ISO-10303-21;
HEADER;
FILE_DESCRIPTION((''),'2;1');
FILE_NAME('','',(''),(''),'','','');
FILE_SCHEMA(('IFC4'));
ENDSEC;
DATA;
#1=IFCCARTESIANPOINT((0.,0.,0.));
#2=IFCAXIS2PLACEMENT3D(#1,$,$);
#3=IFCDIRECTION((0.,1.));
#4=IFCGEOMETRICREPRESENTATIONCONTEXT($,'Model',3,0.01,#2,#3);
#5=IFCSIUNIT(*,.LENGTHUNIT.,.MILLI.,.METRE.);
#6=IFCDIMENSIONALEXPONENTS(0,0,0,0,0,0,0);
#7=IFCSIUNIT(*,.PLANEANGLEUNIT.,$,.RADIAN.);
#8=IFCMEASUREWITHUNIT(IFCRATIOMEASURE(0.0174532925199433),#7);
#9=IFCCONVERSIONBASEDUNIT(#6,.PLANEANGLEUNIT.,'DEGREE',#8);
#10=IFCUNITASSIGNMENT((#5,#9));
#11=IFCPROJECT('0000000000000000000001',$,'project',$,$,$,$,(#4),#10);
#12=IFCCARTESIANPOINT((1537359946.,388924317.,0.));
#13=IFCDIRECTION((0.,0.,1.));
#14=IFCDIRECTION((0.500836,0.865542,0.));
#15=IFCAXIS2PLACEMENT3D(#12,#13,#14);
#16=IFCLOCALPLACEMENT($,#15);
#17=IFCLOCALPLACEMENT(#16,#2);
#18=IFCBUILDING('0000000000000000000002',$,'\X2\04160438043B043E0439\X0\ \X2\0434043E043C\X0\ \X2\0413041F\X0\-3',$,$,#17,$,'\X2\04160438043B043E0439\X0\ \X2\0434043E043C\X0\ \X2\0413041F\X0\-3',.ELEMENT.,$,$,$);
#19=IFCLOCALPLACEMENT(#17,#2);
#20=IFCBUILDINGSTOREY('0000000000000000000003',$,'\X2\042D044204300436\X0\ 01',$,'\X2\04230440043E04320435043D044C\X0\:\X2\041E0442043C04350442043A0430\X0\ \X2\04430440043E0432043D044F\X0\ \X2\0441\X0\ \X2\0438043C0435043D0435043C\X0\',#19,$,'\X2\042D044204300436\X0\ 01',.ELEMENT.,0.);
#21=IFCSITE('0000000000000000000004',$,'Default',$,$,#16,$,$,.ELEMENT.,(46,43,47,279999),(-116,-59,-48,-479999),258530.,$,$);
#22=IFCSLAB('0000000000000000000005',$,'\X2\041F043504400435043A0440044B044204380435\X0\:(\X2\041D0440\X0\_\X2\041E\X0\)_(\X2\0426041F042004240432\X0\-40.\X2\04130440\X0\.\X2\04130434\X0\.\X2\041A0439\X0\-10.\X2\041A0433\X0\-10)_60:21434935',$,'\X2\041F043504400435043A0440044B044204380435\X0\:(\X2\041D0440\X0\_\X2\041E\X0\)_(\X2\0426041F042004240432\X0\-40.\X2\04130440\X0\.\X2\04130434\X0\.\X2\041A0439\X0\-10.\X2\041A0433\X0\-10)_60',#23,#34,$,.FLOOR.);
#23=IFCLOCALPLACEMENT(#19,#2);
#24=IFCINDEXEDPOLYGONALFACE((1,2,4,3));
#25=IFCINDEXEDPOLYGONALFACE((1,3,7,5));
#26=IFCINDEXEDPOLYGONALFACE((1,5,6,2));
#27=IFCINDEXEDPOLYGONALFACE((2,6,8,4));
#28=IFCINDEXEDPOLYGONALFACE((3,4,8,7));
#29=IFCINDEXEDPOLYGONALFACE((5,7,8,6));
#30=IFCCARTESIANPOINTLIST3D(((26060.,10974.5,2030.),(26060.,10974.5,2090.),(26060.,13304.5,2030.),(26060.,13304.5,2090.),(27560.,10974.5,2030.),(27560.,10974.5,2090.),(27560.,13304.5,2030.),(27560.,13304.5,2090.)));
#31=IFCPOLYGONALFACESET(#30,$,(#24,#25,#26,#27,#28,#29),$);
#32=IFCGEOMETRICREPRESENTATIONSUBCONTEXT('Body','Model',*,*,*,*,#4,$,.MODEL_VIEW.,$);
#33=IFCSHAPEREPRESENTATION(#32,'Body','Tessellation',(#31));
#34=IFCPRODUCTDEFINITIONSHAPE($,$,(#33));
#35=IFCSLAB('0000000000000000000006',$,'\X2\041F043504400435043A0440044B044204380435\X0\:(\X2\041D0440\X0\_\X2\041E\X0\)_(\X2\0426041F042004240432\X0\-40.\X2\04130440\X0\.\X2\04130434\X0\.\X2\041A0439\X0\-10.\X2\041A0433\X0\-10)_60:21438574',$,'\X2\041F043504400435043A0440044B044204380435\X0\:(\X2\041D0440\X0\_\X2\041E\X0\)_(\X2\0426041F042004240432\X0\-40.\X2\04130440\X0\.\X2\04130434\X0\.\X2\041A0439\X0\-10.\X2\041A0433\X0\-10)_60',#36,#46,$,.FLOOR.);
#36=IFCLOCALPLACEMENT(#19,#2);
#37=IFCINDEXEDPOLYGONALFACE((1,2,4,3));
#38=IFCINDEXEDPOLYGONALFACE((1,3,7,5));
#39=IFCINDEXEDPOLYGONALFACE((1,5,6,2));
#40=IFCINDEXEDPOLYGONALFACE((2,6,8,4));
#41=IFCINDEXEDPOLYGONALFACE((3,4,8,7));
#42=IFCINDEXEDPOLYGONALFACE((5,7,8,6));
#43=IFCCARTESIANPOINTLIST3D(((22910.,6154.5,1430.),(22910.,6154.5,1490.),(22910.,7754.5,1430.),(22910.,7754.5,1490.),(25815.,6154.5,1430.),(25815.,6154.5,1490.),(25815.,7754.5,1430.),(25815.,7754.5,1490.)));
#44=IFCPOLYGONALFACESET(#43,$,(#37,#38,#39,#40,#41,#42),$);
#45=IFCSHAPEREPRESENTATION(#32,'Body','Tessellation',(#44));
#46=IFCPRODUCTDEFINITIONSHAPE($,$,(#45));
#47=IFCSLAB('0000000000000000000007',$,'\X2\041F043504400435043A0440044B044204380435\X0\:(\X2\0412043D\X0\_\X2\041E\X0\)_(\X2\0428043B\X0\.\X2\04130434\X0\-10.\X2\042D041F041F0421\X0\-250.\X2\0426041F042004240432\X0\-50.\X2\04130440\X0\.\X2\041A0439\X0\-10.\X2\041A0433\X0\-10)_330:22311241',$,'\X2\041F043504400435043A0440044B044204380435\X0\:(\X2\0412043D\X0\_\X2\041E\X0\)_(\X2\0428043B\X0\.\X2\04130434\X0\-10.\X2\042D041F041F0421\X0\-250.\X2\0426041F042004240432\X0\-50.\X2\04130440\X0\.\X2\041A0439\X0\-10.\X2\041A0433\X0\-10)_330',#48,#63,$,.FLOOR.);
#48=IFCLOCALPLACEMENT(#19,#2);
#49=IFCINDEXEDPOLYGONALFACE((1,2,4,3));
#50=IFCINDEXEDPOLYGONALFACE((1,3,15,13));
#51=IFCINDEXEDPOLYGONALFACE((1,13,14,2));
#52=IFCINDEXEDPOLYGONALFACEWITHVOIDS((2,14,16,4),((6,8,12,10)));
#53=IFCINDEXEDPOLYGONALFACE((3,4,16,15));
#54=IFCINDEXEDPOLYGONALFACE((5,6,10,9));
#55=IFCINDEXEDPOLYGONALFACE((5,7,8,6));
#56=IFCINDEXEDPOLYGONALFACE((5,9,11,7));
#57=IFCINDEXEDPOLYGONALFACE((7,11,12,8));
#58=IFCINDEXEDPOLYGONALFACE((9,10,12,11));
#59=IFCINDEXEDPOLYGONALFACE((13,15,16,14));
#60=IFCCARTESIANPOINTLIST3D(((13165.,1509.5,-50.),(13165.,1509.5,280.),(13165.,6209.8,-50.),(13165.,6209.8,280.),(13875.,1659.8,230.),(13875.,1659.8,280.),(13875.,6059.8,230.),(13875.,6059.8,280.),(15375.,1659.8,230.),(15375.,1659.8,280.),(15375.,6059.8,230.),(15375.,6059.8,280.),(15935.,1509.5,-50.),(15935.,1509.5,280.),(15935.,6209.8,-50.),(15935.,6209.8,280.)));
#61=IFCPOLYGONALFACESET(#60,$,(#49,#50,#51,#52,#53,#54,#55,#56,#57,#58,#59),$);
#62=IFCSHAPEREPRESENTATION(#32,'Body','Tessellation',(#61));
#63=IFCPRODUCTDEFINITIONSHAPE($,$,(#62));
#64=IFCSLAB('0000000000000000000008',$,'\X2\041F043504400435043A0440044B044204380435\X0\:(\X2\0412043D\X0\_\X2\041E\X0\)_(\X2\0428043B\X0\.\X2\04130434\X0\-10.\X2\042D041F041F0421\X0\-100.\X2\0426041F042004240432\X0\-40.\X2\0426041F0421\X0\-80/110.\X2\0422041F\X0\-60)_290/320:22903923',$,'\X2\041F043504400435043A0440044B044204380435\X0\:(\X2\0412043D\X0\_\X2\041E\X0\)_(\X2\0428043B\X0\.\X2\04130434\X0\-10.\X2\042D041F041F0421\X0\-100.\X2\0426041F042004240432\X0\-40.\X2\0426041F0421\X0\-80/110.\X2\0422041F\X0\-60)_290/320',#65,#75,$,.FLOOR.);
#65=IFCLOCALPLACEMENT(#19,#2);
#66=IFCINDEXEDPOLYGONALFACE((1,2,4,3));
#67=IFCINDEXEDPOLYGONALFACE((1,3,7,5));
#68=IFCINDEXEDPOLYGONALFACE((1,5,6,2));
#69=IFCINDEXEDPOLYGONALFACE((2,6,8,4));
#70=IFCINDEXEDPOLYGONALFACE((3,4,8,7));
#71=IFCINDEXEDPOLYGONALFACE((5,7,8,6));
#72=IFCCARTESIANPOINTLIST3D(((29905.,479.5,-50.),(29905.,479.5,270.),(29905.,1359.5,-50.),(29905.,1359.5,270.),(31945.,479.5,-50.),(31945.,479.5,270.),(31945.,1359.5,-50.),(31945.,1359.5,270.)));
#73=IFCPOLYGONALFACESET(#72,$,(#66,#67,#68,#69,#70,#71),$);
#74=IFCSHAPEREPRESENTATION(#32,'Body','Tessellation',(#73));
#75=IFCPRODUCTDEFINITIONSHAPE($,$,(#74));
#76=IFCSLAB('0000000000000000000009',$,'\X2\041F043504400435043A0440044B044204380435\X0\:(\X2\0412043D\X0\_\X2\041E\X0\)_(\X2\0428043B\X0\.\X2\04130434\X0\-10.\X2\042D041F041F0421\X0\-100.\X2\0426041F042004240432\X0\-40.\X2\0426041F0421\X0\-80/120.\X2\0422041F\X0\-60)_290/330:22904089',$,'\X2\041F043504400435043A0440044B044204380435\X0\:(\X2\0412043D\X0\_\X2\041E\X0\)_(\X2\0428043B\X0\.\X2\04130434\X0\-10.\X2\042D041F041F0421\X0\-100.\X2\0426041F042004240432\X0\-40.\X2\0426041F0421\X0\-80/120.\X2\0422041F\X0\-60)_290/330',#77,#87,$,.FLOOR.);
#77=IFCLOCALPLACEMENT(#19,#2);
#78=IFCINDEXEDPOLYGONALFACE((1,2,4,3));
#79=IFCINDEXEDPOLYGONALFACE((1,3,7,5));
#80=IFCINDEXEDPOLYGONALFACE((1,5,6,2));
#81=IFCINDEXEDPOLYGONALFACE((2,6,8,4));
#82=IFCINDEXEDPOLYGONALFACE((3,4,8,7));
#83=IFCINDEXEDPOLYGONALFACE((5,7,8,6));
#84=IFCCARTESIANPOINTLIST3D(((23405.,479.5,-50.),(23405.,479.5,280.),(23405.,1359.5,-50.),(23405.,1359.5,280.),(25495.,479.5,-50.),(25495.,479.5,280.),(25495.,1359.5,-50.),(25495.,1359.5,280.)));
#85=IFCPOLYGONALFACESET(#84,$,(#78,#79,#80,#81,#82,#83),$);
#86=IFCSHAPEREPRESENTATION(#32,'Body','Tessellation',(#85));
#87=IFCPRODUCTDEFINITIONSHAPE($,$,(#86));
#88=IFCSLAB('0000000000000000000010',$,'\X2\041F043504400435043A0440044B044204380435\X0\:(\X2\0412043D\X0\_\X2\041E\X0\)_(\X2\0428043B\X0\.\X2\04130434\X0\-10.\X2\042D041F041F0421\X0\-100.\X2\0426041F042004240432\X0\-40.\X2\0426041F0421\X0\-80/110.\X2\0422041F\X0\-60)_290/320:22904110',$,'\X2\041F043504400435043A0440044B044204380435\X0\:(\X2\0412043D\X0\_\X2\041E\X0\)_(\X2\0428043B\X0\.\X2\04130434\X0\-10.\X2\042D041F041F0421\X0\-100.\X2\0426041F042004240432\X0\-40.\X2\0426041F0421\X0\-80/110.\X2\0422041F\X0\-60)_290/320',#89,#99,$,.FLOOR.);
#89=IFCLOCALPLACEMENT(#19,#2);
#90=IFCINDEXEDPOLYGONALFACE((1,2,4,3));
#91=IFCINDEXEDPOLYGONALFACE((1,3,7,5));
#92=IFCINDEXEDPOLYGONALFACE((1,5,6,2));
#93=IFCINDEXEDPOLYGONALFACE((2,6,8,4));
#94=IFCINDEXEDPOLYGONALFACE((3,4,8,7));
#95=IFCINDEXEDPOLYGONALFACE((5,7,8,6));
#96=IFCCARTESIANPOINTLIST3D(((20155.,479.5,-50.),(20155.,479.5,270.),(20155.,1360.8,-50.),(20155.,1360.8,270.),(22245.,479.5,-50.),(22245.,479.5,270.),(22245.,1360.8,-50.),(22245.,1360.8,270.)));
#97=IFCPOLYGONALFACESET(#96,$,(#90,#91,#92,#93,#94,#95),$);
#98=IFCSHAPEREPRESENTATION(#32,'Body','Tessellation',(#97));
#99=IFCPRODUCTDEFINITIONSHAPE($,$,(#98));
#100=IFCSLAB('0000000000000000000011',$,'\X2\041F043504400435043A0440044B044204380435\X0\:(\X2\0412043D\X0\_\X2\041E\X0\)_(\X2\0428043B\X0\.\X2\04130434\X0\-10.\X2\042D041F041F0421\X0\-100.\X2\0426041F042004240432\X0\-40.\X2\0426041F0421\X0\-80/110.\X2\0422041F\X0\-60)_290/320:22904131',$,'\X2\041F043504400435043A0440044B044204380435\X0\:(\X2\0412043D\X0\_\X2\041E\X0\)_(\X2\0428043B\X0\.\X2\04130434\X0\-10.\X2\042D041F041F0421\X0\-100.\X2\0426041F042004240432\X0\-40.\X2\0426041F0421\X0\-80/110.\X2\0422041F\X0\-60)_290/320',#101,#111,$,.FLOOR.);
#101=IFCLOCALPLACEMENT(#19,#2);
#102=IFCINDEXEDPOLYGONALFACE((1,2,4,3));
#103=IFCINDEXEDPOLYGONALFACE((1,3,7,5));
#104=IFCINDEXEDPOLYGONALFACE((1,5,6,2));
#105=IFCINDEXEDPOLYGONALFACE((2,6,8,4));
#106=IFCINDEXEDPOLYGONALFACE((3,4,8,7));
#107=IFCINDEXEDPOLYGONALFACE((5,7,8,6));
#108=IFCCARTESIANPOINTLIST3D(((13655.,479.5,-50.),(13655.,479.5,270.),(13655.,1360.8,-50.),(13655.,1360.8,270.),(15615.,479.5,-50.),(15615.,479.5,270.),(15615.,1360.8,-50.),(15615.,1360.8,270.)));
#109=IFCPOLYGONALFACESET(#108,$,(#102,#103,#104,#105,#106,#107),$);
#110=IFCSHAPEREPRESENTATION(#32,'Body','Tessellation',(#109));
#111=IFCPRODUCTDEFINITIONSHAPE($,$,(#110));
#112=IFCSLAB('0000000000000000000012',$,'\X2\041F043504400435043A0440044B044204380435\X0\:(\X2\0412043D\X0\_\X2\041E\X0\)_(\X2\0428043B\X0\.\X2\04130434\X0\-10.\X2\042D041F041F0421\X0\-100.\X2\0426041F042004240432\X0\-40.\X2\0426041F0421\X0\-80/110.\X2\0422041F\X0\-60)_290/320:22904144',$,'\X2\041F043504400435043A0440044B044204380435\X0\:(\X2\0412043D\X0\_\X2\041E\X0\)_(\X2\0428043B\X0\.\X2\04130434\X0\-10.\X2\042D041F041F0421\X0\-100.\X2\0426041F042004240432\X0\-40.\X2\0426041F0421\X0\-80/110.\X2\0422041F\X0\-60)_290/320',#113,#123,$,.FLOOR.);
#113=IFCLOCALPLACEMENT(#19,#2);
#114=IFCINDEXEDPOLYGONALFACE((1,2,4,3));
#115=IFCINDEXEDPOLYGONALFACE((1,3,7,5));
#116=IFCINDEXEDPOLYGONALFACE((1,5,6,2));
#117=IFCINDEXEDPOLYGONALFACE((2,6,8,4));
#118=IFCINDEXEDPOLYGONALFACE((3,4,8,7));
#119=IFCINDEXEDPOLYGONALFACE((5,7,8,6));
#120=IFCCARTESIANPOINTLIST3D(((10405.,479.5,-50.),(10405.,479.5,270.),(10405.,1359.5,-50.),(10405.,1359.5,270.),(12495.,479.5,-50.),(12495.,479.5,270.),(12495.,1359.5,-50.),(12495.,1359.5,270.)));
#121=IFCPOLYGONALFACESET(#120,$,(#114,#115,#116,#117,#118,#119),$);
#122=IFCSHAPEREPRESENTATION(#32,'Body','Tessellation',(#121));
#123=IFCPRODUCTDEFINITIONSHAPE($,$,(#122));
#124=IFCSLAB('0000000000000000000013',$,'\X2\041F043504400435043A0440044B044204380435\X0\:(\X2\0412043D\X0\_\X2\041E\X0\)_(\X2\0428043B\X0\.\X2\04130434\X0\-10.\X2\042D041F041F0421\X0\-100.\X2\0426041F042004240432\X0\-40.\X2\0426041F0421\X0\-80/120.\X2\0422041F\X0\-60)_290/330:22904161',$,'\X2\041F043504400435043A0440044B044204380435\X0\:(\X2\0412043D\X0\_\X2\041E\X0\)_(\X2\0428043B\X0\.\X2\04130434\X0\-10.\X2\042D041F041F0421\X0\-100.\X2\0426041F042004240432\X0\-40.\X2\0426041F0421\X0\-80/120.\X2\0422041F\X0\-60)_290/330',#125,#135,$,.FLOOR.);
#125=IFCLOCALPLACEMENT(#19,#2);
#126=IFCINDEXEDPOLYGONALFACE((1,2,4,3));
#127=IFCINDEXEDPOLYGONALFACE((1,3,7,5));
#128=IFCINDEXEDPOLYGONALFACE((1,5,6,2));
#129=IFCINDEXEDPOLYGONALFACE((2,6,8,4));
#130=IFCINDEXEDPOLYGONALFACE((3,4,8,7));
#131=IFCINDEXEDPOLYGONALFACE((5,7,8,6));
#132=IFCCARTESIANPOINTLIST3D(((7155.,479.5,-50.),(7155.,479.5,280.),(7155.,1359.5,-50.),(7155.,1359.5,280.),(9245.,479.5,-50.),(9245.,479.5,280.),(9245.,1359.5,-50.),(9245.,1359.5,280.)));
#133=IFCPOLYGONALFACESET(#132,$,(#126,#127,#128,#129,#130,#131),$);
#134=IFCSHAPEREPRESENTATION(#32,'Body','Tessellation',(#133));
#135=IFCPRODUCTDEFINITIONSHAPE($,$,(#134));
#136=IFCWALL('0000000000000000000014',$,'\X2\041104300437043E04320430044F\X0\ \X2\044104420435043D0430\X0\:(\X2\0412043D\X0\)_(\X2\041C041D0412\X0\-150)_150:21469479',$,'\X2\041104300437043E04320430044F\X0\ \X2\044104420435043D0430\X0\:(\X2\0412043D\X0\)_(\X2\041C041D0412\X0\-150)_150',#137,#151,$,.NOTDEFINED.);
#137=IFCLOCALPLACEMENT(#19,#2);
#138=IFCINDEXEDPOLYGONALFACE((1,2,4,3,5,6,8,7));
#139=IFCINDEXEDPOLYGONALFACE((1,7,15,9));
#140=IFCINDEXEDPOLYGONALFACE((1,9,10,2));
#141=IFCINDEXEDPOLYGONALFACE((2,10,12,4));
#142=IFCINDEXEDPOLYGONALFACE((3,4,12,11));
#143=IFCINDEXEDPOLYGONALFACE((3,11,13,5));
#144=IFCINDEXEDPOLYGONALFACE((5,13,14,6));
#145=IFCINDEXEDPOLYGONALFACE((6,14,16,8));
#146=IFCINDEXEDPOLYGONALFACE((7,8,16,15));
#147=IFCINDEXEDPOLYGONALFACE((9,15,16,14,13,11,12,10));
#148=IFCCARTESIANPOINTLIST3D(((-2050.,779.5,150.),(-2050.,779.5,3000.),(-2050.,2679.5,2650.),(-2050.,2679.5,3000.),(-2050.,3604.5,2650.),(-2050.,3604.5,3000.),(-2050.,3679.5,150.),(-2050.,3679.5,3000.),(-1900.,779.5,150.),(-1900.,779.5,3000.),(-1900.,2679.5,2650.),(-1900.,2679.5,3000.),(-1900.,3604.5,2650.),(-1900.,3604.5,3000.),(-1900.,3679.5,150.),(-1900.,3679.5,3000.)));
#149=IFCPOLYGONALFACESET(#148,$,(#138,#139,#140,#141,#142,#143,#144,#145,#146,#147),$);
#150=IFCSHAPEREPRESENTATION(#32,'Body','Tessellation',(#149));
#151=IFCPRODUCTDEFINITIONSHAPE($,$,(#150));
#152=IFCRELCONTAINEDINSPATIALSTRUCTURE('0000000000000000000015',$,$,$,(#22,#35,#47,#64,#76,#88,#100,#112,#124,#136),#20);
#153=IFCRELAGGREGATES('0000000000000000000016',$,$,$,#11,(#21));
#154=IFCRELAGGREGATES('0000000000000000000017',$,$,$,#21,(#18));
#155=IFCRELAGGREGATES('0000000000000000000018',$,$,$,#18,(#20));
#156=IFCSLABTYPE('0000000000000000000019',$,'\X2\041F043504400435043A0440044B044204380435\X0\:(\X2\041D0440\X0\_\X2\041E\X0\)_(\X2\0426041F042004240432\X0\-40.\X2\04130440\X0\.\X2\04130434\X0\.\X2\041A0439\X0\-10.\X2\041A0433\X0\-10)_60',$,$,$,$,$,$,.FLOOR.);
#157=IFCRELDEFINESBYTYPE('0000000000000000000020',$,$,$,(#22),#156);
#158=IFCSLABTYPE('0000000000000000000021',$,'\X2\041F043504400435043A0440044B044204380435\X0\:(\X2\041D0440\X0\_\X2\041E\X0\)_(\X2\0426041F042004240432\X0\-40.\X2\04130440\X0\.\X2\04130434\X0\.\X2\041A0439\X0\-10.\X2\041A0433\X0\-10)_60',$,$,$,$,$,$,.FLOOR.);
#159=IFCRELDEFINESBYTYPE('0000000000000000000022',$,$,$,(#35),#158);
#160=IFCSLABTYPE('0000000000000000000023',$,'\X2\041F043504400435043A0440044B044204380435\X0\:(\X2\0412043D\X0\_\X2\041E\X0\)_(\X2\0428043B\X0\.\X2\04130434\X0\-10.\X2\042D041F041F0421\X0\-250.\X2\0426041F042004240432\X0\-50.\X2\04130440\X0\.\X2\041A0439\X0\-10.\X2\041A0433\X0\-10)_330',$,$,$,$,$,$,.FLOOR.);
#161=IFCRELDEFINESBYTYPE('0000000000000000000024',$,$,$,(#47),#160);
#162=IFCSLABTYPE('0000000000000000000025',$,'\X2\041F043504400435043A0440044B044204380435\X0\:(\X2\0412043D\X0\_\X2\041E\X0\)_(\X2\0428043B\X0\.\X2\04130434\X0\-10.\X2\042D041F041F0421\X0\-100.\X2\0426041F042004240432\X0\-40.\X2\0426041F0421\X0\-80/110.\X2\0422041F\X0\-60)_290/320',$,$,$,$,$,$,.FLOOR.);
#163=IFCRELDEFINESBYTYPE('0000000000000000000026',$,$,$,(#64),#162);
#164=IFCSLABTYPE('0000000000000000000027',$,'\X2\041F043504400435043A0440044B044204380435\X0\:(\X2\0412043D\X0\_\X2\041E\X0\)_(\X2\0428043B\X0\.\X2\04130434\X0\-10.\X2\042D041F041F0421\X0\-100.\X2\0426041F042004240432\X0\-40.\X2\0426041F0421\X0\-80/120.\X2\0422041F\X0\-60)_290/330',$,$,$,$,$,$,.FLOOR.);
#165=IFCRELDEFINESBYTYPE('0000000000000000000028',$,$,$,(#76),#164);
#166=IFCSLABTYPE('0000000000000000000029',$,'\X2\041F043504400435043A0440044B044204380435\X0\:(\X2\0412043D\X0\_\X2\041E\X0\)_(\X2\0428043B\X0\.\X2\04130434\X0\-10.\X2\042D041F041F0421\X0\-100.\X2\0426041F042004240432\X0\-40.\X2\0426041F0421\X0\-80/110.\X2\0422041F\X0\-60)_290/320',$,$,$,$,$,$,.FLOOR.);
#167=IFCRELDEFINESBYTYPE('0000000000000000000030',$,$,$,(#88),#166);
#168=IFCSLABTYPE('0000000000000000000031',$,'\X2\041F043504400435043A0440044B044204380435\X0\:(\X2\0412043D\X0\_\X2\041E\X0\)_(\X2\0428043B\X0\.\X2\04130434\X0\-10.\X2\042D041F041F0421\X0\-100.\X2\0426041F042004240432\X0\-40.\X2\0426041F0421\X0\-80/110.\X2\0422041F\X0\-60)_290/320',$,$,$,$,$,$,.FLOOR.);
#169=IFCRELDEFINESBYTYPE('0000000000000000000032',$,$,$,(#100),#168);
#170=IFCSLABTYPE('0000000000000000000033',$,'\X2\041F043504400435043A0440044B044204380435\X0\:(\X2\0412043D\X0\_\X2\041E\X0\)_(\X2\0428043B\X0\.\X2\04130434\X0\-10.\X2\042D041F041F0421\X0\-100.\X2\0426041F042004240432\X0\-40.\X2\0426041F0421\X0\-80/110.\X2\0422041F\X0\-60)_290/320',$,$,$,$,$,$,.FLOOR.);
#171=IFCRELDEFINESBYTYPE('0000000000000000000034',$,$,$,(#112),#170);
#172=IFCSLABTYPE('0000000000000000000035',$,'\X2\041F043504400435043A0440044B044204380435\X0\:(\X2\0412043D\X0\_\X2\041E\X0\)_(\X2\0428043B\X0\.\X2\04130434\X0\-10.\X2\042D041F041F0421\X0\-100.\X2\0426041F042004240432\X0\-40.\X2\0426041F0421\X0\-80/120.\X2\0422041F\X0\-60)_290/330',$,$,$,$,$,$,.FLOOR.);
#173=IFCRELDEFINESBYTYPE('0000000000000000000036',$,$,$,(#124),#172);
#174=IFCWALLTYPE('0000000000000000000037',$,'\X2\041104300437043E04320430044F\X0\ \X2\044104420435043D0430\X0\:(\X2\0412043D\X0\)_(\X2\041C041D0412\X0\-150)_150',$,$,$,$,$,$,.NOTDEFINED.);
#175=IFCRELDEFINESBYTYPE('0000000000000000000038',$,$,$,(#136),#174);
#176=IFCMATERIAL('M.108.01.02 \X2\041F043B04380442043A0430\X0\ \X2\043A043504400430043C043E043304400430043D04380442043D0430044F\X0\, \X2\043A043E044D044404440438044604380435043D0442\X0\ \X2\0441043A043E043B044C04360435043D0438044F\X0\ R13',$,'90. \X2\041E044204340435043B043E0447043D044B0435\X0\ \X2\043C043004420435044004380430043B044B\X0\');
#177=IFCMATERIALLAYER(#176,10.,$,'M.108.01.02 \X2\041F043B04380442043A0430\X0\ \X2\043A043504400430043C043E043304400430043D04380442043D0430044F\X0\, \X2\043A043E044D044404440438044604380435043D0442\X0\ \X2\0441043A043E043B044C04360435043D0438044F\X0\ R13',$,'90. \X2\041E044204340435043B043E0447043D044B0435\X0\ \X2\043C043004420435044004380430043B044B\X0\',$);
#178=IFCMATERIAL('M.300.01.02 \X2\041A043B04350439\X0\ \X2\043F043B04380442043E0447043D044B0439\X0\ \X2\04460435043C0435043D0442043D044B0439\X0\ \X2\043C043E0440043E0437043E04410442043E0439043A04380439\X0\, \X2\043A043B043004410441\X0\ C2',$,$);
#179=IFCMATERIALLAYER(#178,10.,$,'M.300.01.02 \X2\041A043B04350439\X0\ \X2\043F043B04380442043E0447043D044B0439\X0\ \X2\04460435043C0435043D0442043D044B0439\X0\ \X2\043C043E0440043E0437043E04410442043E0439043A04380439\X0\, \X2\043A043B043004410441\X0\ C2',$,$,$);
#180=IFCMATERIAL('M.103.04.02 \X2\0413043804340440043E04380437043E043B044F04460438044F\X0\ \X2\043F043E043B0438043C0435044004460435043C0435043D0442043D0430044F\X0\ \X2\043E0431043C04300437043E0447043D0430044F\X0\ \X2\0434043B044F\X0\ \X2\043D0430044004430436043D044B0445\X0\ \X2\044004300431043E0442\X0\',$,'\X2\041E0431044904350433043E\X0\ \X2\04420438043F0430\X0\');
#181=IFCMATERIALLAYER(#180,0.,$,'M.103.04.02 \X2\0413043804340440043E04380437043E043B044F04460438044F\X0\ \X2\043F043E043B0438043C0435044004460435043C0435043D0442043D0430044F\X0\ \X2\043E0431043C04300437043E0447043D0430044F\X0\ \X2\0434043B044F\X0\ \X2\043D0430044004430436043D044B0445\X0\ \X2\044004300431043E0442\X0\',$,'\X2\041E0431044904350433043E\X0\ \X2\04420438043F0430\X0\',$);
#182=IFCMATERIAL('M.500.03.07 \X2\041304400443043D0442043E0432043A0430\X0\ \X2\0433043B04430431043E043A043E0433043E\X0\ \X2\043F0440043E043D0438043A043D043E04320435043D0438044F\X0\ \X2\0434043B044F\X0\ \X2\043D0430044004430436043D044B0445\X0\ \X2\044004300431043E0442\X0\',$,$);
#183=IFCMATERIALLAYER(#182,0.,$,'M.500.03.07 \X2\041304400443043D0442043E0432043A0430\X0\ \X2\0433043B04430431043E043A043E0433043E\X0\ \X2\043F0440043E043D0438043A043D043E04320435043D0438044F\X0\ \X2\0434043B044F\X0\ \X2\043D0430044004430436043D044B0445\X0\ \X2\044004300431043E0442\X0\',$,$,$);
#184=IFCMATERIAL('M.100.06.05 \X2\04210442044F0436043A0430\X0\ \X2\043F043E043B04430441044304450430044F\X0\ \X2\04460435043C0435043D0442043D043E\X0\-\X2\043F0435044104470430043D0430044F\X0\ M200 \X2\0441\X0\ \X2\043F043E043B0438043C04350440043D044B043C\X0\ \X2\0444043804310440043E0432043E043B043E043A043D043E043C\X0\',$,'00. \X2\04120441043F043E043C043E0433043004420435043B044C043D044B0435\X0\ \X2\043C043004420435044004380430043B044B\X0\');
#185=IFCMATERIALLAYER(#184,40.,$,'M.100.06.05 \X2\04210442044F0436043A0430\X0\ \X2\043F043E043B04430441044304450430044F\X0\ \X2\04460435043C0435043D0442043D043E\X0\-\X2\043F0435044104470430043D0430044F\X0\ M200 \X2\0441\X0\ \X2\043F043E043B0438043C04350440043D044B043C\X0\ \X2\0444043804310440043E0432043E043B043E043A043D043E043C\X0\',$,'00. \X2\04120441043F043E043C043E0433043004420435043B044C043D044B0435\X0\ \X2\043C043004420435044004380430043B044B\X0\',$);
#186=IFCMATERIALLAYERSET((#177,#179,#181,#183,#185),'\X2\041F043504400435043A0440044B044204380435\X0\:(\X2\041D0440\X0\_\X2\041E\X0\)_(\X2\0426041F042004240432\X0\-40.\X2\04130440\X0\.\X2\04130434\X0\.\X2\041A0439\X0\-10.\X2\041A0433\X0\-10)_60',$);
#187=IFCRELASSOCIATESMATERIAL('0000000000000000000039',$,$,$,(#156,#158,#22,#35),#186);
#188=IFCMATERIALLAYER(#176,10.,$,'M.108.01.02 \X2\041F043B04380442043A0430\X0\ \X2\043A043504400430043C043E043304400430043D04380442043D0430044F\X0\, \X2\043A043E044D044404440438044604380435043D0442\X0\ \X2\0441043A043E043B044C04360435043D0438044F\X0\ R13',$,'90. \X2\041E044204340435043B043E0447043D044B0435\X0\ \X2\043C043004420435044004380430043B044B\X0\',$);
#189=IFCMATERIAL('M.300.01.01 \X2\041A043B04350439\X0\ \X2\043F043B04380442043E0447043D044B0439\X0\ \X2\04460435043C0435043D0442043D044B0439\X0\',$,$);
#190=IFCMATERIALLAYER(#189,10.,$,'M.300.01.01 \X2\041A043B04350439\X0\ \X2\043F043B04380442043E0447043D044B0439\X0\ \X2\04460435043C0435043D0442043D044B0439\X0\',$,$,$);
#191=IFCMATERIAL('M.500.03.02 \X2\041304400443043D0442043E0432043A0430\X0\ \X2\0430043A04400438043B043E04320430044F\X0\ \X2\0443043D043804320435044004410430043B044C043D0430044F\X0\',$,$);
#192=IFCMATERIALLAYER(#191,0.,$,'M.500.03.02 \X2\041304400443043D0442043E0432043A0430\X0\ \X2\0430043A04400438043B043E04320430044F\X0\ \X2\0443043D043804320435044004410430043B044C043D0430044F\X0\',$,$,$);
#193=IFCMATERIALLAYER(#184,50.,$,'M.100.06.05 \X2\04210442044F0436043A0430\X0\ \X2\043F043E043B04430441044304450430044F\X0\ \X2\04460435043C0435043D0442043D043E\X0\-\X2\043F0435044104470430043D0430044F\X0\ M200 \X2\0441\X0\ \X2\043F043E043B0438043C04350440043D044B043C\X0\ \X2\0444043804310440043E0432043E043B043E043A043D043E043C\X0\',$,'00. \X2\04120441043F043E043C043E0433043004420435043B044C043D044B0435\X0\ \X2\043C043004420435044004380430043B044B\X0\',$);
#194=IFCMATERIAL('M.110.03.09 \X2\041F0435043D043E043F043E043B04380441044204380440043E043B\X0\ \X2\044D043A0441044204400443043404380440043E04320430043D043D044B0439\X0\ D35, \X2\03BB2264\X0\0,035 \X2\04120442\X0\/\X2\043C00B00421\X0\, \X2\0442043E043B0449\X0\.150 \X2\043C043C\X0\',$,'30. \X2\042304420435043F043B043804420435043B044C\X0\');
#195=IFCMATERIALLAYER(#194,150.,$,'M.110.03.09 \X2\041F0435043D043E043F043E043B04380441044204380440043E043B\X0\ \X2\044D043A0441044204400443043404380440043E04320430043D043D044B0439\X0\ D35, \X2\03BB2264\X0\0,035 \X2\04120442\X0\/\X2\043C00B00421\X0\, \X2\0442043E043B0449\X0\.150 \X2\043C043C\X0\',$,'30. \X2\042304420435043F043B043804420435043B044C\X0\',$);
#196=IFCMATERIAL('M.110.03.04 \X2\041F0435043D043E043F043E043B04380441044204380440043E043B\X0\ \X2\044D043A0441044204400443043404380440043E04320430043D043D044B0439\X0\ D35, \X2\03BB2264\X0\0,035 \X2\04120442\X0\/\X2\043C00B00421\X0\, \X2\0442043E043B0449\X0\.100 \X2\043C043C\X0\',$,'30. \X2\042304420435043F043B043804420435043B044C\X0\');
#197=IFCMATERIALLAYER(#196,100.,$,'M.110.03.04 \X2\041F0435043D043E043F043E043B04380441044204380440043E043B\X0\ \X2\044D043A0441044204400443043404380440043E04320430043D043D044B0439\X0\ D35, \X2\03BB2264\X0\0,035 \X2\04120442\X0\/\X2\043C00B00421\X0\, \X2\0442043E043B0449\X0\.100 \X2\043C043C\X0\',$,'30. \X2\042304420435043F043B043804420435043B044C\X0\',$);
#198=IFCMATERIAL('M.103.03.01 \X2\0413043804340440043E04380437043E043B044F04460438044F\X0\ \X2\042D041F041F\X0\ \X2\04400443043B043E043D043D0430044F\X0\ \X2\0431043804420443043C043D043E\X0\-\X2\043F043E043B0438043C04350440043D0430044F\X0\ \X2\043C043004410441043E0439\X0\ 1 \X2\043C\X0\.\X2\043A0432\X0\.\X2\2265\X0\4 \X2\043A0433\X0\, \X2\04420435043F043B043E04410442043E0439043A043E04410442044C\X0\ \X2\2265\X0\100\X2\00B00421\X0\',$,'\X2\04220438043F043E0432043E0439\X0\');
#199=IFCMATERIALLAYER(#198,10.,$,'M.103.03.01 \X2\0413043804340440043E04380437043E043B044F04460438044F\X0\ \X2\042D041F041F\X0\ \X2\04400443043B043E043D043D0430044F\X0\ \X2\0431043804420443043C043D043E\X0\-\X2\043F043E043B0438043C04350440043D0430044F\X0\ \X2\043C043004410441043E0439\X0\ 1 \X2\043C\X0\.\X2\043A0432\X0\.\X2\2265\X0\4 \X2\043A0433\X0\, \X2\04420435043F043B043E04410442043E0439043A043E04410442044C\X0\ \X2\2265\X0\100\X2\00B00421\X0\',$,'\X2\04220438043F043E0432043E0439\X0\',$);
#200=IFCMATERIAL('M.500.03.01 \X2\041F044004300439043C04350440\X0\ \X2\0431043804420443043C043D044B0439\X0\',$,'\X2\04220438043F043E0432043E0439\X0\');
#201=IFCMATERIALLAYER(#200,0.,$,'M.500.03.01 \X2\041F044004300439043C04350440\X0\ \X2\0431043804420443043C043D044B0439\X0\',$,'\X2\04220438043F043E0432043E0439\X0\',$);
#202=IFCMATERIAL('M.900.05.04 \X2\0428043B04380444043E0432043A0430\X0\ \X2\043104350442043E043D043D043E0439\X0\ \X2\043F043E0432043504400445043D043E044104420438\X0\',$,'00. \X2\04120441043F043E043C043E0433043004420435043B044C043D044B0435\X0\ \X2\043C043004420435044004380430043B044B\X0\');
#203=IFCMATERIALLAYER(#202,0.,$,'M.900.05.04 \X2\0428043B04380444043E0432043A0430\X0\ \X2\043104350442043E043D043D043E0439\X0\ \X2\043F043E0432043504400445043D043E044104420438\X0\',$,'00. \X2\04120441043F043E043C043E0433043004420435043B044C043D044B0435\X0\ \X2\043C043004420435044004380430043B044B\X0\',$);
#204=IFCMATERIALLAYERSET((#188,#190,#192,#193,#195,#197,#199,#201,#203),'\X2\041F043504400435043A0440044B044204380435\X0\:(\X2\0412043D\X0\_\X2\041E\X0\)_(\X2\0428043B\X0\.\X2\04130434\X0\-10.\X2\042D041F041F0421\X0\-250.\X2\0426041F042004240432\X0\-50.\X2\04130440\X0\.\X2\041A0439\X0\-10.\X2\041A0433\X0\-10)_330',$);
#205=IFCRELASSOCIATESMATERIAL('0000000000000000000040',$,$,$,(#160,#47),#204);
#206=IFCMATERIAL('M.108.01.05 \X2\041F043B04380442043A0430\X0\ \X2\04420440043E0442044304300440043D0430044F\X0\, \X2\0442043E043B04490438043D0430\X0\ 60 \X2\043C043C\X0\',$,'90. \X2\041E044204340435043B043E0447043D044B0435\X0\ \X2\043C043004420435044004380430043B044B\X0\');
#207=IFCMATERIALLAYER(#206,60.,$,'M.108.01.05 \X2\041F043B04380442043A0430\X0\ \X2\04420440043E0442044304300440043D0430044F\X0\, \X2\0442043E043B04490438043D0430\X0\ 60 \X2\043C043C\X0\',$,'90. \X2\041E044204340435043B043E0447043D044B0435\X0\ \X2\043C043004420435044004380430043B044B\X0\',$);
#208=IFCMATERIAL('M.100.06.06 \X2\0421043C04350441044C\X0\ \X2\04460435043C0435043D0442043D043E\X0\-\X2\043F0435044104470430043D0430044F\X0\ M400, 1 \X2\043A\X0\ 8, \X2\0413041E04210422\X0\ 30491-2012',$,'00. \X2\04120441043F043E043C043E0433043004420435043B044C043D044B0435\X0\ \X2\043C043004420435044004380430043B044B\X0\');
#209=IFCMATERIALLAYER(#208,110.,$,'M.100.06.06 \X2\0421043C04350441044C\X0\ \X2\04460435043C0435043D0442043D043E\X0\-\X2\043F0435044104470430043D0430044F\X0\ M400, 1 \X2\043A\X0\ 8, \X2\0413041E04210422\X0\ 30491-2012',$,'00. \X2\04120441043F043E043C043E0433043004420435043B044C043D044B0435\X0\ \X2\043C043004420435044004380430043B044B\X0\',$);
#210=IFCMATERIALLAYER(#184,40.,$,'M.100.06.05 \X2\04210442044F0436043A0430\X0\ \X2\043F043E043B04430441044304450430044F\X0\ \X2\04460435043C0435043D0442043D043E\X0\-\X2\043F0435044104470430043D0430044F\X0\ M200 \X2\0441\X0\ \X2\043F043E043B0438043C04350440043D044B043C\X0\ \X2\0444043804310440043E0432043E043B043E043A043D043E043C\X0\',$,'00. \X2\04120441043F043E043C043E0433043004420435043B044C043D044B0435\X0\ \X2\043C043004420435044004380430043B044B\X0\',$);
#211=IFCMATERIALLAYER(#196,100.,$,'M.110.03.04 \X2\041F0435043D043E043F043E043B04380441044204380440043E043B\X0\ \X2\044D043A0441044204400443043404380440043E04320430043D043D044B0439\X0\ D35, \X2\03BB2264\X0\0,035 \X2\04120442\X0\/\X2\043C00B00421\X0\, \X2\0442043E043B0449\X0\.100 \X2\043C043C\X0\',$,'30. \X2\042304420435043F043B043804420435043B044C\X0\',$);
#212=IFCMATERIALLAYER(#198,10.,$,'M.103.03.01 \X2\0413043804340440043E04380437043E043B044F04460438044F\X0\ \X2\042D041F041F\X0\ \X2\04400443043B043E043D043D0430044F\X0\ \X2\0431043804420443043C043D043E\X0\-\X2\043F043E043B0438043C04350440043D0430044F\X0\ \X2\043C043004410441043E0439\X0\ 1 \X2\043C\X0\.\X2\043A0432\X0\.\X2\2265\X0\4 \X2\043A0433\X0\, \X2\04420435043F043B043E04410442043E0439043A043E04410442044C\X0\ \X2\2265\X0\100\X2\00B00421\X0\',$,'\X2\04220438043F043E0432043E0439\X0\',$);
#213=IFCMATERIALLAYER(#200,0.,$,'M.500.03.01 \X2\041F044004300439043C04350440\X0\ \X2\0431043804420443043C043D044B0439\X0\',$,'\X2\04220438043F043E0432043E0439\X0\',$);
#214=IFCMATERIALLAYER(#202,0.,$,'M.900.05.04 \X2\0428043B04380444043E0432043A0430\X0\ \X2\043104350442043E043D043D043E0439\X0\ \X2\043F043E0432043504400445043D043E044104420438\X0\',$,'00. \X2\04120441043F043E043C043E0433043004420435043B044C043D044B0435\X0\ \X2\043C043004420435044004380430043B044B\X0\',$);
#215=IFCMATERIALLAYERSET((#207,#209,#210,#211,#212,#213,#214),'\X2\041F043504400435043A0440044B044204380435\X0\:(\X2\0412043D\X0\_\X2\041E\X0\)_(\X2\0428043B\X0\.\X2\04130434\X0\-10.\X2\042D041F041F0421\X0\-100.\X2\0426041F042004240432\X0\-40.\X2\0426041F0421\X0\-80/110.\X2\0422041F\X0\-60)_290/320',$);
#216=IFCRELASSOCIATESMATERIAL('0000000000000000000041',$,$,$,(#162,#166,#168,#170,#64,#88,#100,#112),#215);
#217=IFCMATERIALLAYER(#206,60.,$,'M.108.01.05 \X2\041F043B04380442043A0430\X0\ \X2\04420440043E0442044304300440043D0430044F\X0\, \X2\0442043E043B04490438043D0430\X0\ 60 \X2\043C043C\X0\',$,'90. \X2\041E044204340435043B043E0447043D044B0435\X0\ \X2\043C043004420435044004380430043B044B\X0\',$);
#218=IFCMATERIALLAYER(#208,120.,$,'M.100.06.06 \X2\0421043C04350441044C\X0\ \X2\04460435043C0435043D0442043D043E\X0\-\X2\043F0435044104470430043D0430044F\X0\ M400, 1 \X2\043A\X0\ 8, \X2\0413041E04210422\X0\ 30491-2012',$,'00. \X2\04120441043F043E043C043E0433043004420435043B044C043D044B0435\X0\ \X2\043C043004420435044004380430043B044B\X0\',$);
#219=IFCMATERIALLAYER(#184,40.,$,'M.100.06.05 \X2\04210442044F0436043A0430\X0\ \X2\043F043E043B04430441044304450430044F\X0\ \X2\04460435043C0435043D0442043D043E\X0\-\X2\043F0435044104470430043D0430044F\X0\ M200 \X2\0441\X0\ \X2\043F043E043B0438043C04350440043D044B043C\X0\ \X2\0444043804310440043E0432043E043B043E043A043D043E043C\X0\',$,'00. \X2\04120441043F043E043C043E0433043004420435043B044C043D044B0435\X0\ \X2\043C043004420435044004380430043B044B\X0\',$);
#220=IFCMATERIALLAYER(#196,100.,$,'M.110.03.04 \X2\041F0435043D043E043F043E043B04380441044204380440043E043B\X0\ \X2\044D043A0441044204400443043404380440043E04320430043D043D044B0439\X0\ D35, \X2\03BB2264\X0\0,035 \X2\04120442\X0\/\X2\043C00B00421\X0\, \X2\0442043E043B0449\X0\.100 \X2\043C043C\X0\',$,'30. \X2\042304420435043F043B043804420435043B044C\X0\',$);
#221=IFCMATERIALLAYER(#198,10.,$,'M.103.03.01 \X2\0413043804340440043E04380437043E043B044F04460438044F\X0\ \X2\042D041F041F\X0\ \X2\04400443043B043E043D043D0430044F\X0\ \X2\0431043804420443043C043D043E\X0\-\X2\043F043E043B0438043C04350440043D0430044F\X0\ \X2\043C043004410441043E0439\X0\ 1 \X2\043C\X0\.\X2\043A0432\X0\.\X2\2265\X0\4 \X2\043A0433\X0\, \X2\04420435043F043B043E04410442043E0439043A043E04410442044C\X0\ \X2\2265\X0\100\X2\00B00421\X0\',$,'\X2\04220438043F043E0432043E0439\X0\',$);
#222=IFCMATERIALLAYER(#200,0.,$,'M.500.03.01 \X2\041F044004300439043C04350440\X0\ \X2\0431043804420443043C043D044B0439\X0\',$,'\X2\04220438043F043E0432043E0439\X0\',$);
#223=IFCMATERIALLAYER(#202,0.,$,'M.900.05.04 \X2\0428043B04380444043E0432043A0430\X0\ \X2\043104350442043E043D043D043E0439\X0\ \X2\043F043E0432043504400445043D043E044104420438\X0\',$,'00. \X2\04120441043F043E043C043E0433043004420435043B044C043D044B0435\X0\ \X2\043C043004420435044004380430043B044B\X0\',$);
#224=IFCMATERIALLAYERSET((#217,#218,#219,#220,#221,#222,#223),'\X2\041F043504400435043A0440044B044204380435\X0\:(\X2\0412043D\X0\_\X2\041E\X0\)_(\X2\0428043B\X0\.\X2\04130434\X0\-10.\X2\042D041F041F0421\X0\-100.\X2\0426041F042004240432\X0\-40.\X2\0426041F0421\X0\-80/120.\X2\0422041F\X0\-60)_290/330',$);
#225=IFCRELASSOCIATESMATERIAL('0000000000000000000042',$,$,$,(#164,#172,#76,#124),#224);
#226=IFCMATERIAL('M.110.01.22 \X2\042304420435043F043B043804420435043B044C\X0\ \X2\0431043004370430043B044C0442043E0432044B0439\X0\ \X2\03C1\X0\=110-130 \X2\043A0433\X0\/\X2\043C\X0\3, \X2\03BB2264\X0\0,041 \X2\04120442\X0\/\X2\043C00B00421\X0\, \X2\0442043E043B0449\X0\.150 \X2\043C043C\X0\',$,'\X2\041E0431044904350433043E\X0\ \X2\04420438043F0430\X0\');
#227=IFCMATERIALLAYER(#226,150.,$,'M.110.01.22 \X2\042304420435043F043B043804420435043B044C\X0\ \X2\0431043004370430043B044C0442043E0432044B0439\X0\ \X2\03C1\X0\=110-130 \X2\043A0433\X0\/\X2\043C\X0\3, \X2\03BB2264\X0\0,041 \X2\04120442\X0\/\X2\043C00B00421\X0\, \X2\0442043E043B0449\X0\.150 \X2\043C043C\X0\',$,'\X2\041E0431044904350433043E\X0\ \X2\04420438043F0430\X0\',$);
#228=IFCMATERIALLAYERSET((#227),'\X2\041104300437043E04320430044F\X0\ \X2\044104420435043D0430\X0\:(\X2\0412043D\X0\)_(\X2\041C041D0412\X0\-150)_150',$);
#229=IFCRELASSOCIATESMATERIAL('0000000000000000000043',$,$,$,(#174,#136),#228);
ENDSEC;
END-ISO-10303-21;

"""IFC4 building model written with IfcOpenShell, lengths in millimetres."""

from ifc_helpers import new_model, entity, si_unit, converted_unit, direction, frame, frame_2d, origin, origin_2d_with_axis, place, context, subcontext, project, spatial, polyline, rectangle, extrude, boolean, clip, bounded_halfspace, material, layer, layer_set, layer_usage, type_object, element, save


model = new_model("IFC4")

# Units and contexts
model_context = context("Model", 3, precision=0.01, world=origin(), true_north=direction((0.0, 1.0)))
body_context = subcontext(model_context, "Body", "Model", "MODEL_VIEW")
ifc_project = project(units=[si_unit("LENGTHUNIT", "METRE", prefix="MILLI"), converted_unit("PLANEANGLEUNIT", "DEGREE", entity("IfcRatioMeasure", 0.0174532925199433), si_unit("PLANEANGLEUNIT", "RADIAN"), dimensions=[0, 0, 0, 0, 0, 0, 0])], contexts=[model_context])

# Site, building, storey
site_placement = place(None, frame((1537359946.0, 388924317.0, 0.0), z_axis=(0.0, 0.0, 1.0), x_axis=(0.500836, 0.865542, 0.0)))
site = spatial("IfcSite", under=ifc_project, at=site_placement, Name="Default", CompositionType="ELEMENT", RefLatitude=(46, 43, 47, 279999), RefLongitude=(-116, -59, -48, -479999), RefElevation=258530.0)
building_placement = place(site_placement, origin())
building = spatial("IfcBuilding", under=site, at=building_placement, Name="Жилой дом ГП-3", LongName="Жилой дом ГП-3", CompositionType="ELEMENT")
storey_placement = place(building_placement, origin())
storey = spatial("IfcBuildingStorey", under=building, at=storey_placement, Name="Этаж 01", ObjectType="Уровень:Отметка уровня с именем", LongName="Этаж 01", CompositionType="ELEMENT", Elevation=0.0)

# Slabs
ifc_material_1 = material(Name="M.108.01.02 Плитка керамогранитная, коэффициент скольжения R13", Category="90. Отделочные материалы")
ifc_layer_1 = layer(ifc_material_1, 10.0, Name="M.108.01.02 Плитка керамогранитная, коэффициент скольжения R13", Category="90. Отделочные материалы")
ifc_material_2 = material(Name="M.300.01.02 Клей плиточный цементный морозостойкий, класс C2")
ifc_layer_2 = layer(ifc_material_2, 10.0, Name="M.300.01.02 Клей плиточный цементный морозостойкий, класс C2")
ifc_material_3 = material(Name="M.103.04.02 Гидроизоляция полимерцементная обмазочная для наружных работ", Category="Общего типа")
ifc_layer_3 = layer(ifc_material_3, 0.0, Name="M.103.04.02 Гидроизоляция полимерцементная обмазочная для наружных работ", Category="Общего типа")
ifc_material_4 = material(Name="M.500.03.07 Грунтовка глубокого проникновения для наружных работ")
ifc_layer_4 = layer(ifc_material_4, 0.0, Name="M.500.03.07 Грунтовка глубокого проникновения для наружных работ")
ifc_material_5 = material(Name="M.100.06.05 Стяжка полусухая цементно-песчаная M200 с полимерным фиброволокном", Category="00. Вспомогательные материалы")
ifc_layer_5 = layer(ifc_material_5, 40.0, Name="M.100.06.05 Стяжка полусухая цементно-песчаная M200 с полимерным фиброволокном", Category="00. Вспомогательные материалы")
ifc_layer_set_1 = layer_set([ifc_layer_1, ifc_layer_2, ifc_layer_3, ifc_layer_4, ifc_layer_5], Name="Перекрытие:(Нр_О)_(ЦПРФв-40.Гр.Гд.Кй-10.Кг-10)_60")
ifc_layer_usage_1 = layer_usage(ifc_layer_set_1, "AXIS3", "POSITIVE", 0.0)
slab_type_1 = type_object("IfcSlabType", Name="Перекрытие:(Нр_О)_(ЦПРФв-40.Гр.Гд.Кй-10.Кг-10)_60", PredefinedType="FLOOR", material=ifc_layer_set_1)
slab_1_placement = place(storey_placement, origin())
element("IfcSlab", 1, at=slab_1_placement, inside=storey, type_object=slab_type_1, material=ifc_layer_usage_1, Name="Перекрытие:(Нр_О)_(ЦПРФв-40.Гр.Гд.Кй-10.Кг-10)_60:21434935", ObjectType="Перекрытие:(Нр_О)_(ЦПРФв-40.Гр.Гд.Кй-10.Кг-10)_60", PredefinedType="FLOOR", context=body_context, shape_type="SweptSolid", body=[
    extrude(rectangle(XDim=2330.0, YDim=1500.0, at=frame_2d((0.0, 0.0), x_axis=(1.0, 0.0))), frame((26810.0, 12139.5, 2090.0), z_axis=(0.0, 0.0, -1.0), x_axis=(0.0, 1.0, 0.0)), (0.0, 0.0, 1.0), 60.0),
])
ifc_layer_usage_2 = layer_usage(ifc_layer_set_1, "AXIS3", "POSITIVE", 0.0)
slab_type_2 = type_object("IfcSlabType", Name="Перекрытие:(Нр_О)_(ЦПРФв-40.Гр.Гд.Кй-10.Кг-10)_60", PredefinedType="FLOOR", material=ifc_layer_set_1)
slab_2_placement = place(storey_placement, origin())
element("IfcSlab", 2, at=slab_2_placement, inside=storey, type_object=slab_type_2, material=ifc_layer_usage_2, Name="Перекрытие:(Нр_О)_(ЦПРФв-40.Гр.Гд.Кй-10.Кг-10)_60:21438574", ObjectType="Перекрытие:(Нр_О)_(ЦПРФв-40.Гр.Гд.Кй-10.Кг-10)_60", PredefinedType="FLOOR", context=body_context, shape_type="SweptSolid", body=[
    extrude(rectangle(XDim=1600.0, YDim=2905.0, at=frame_2d((0.0, 0.0), x_axis=(1.0, 0.0))), frame((24362.5, 6954.5, 1490.0), z_axis=(0.0, 0.0, -1.0), x_axis=(0.0, 1.0, 0.0)), (0.0, 0.0, 1.0), 60.0),
])
ifc_material_6 = material(Name="M.300.01.01 Клей плиточный цементный")
ifc_material_7 = material(Name="M.500.03.02 Грунтовка акриловая универсальная")
ifc_layer_6 = layer(ifc_material_1, 10.0, Name="M.108.01.02 Плитка керамогранитная, коэффициент скольжения R13", Category="90. Отделочные материалы")
ifc_layer_7 = layer(ifc_material_6, 10.0, Name="M.300.01.01 Клей плиточный цементный")
ifc_layer_8 = layer(ifc_material_7, 0.0, Name="M.500.03.02 Грунтовка акриловая универсальная")
ifc_layer_9 = layer(ifc_material_5, 50.0, Name="M.100.06.05 Стяжка полусухая цементно-песчаная M200 с полимерным фиброволокном", Category="00. Вспомогательные материалы")
ifc_material_8 = material(Name="M.110.03.09 Пенополистирол экструдированный D35, λ≤0,035 Вт/м°С, толщ.150 мм", Category="30. Утеплитель")
ifc_layer_10 = layer(ifc_material_8, 150.0, Name="M.110.03.09 Пенополистирол экструдированный D35, λ≤0,035 Вт/м°С, толщ.150 мм", Category="30. Утеплитель")
ifc_material_9 = material(Name="M.110.03.04 Пенополистирол экструдированный D35, λ≤0,035 Вт/м°С, толщ.100 мм", Category="30. Утеплитель")
ifc_layer_11 = layer(ifc_material_9, 100.0, Name="M.110.03.04 Пенополистирол экструдированный D35, λ≤0,035 Вт/м°С, толщ.100 мм", Category="30. Утеплитель")
ifc_material_10 = material(Name="M.103.03.01 Гидроизоляция ЭПП рулонная битумно-полимерная массой 1 м.кв.≥4 кг, теплостойкость ≥100°С", Category="Типовой")
ifc_layer_12 = layer(ifc_material_10, 10.0, Name="M.103.03.01 Гидроизоляция ЭПП рулонная битумно-полимерная массой 1 м.кв.≥4 кг, теплостойкость ≥100°С", Category="Типовой")
ifc_material_11 = material(Name="M.500.03.01 Праймер битумный", Category="Типовой")
ifc_layer_13 = layer(ifc_material_11, 0.0, Name="M.500.03.01 Праймер битумный", Category="Типовой")
ifc_material_12 = material(Name="M.900.05.04 Шлифовка бетонной поверхности", Category="00. Вспомогательные материалы")
ifc_layer_14 = layer(ifc_material_12, 0.0, Name="M.900.05.04 Шлифовка бетонной поверхности", Category="00. Вспомогательные материалы")
ifc_layer_set_2 = layer_set([ifc_layer_6, ifc_layer_7, ifc_layer_8, ifc_layer_9, ifc_layer_10, ifc_layer_11, ifc_layer_12, ifc_layer_13, ifc_layer_14], Name="Перекрытие:(Вн_О)_(Шл.Гд-10.ЭППС-250.ЦПРФв-50.Гр.Кй-10.Кг-10)_330")
ifc_layer_usage_3 = layer_usage(ifc_layer_set_2, "AXIS3", "POSITIVE", 0.0)
slab_type_3 = type_object("IfcSlabType", Name="Перекрытие:(Вн_О)_(Шл.Гд-10.ЭППС-250.ЦПРФв-50.Гр.Кй-10.Кг-10)_330", PredefinedType="FLOOR", material=ifc_layer_set_2)
slab_3_placement = place(storey_placement, origin())
element("IfcSlab", 3, at=slab_3_placement, inside=storey, type_object=slab_type_3, material=ifc_layer_usage_3, Name="Перекрытие:(Вн_О)_(Шл.Гд-10.ЭППС-250.ЦПРФв-50.Гр.Кй-10.Кг-10)_330:22311241", ObjectType="Перекрытие:(Вн_О)_(Шл.Гд-10.ЭППС-250.ЦПРФв-50.Гр.Кй-10.Кг-10)_330", PredefinedType="FLOOR", context=body_context, shape_type="CSG", body=[
    boolean("DIFFERENCE", clip(extrude(rectangle(XDim=4700.2, YDim=2770.0, at=frame_2d((0.0, 0.0), x_axis=(1.0, 0.0))), frame((14550.0, 3859.7, 280.0), z_axis=(0.0, 0.0, -1.0), x_axis=(0.0, 1.0, 0.0)), (0.0, 0.0, 1.0), 330.0), bounded_halfspace(frame((13875.0, 6059.8, 230.0)), False, frame((14550.0, 3859.7, 280.0), z_axis=(0.0, 0.0, -1.0), x_axis=(0.0, 1.0, 0.0)), polyline([(2200.1, 825.0), (2200.1, -675.0), (-2199.9, -675.0), (-2199.9, 825.0), (2200.1, 825.0)]))), extrude(rectangle(XDim=4400.0, YDim=1500.0, at=frame_2d((0.0, 0.0), x_axis=(1.0, 0.0))), frame((14625.0, 3859.8, 230.0), z_axis=(0.0, 0.0, 1.0), x_axis=(0.0, 1.0, 0.0)), (0.0, 0.0, 1.0), 50.0)),
])

# Slabs
ifc_material_13 = material(Name="M.108.01.05 Плитка тротуарная, толщина 60 мм", Category="90. Отделочные материалы")
ifc_layer_15 = layer(ifc_material_13, 60.0, Name="M.108.01.05 Плитка тротуарная, толщина 60 мм", Category="90. Отделочные материалы")
ifc_material_14 = material(Name="M.100.06.06 Смесь цементно-песчаная M400, 1 к 8, ГОСТ 30491-2012", Category="00. Вспомогательные материалы")
ifc_layer_16 = layer(ifc_material_14, 110.0, Name="M.100.06.06 Смесь цементно-песчаная M400, 1 к 8, ГОСТ 30491-2012", Category="00. Вспомогательные материалы")
ifc_layer_17 = layer(ifc_material_5, 40.0, Name="M.100.06.05 Стяжка полусухая цементно-песчаная M200 с полимерным фиброволокном", Category="00. Вспомогательные материалы")
ifc_layer_18 = layer(ifc_material_9, 100.0, Name="M.110.03.04 Пенополистирол экструдированный D35, λ≤0,035 Вт/м°С, толщ.100 мм", Category="30. Утеплитель")
ifc_layer_19 = layer(ifc_material_10, 10.0, Name="M.103.03.01 Гидроизоляция ЭПП рулонная битумно-полимерная массой 1 м.кв.≥4 кг, теплостойкость ≥100°С", Category="Типовой")
ifc_layer_20 = layer(ifc_material_11, 0.0, Name="M.500.03.01 Праймер битумный", Category="Типовой")
ifc_layer_21 = layer(ifc_material_12, 0.0, Name="M.900.05.04 Шлифовка бетонной поверхности", Category="00. Вспомогательные материалы")
ifc_layer_set_3 = layer_set([ifc_layer_15, ifc_layer_16, ifc_layer_17, ifc_layer_18, ifc_layer_19, ifc_layer_20, ifc_layer_21], Name="Перекрытие:(Вн_О)_(Шл.Гд-10.ЭППС-100.ЦПРФв-40.ЦПС-80/110.ТП-60)_290/320")
ifc_layer_usage_4 = layer_usage(ifc_layer_set_3, "AXIS3", "POSITIVE", 0.0)
slab_type_4 = type_object("IfcSlabType", Name="Перекрытие:(Вн_О)_(Шл.Гд-10.ЭППС-100.ЦПРФв-40.ЦПС-80/110.ТП-60)_290/320", PredefinedType="FLOOR", material=ifc_layer_set_3)
slab_4_placement = place(storey_placement, origin())
element("IfcSlab", 4, at=slab_4_placement, inside=storey, type_object=slab_type_4, material=ifc_layer_usage_4, Name="Перекрытие:(Вн_О)_(Шл.Гд-10.ЭППС-100.ЦПРФв-40.ЦПС-80/110.ТП-60)_290/320:22903923", ObjectType="Перекрытие:(Вн_О)_(Шл.Гд-10.ЭППС-100.ЦПРФв-40.ЦПС-80/110.ТП-60)_290/320", PredefinedType="FLOOR", context=body_context, shape_type="SweptSolid", body=[
    extrude(rectangle(XDim=880.0, YDim=2040.0, at=frame_2d((0.0, 0.0), x_axis=(1.0, 0.0))), frame((30925.0, 919.5, 270.0), z_axis=(0.0, 0.0, -1.0), x_axis=(0.0, 1.0, 0.0)), (0.0, 0.0, 1.0), 320.0),
])
ifc_layer_22 = layer(ifc_material_13, 60.0, Name="M.108.01.05 Плитка тротуарная, толщина 60 мм", Category="90. Отделочные материалы")
ifc_layer_23 = layer(ifc_material_14, 120.0, Name="M.100.06.06 Смесь цементно-песчаная M400, 1 к 8, ГОСТ 30491-2012", Category="00. Вспомогательные материалы")
ifc_layer_24 = layer(ifc_material_5, 40.0, Name="M.100.06.05 Стяжка полусухая цементно-песчаная M200 с полимерным фиброволокном", Category="00. Вспомогательные материалы")
ifc_layer_25 = layer(ifc_material_9, 100.0, Name="M.110.03.04 Пенополистирол экструдированный D35, λ≤0,035 Вт/м°С, толщ.100 мм", Category="30. Утеплитель")
ifc_layer_26 = layer(ifc_material_10, 10.0, Name="M.103.03.01 Гидроизоляция ЭПП рулонная битумно-полимерная массой 1 м.кв.≥4 кг, теплостойкость ≥100°С", Category="Типовой")
ifc_layer_27 = layer(ifc_material_11, 0.0, Name="M.500.03.01 Праймер битумный", Category="Типовой")
ifc_layer_28 = layer(ifc_material_12, 0.0, Name="M.900.05.04 Шлифовка бетонной поверхности", Category="00. Вспомогательные материалы")
ifc_layer_set_4 = layer_set([ifc_layer_22, ifc_layer_23, ifc_layer_24, ifc_layer_25, ifc_layer_26, ifc_layer_27, ifc_layer_28], Name="Перекрытие:(Вн_О)_(Шл.Гд-10.ЭППС-100.ЦПРФв-40.ЦПС-80/120.ТП-60)_290/330")
ifc_layer_usage_5 = layer_usage(ifc_layer_set_4, "AXIS3", "POSITIVE", 0.0)
slab_type_5 = type_object("IfcSlabType", Name="Перекрытие:(Вн_О)_(Шл.Гд-10.ЭППС-100.ЦПРФв-40.ЦПС-80/120.ТП-60)_290/330", PredefinedType="FLOOR", material=ifc_layer_set_4)
slab_5_placement = place(storey_placement, origin())
element("IfcSlab", 5, at=slab_5_placement, inside=storey, type_object=slab_type_5, material=ifc_layer_usage_5, Name="Перекрытие:(Вн_О)_(Шл.Гд-10.ЭППС-100.ЦПРФв-40.ЦПС-80/120.ТП-60)_290/330:22904089", ObjectType="Перекрытие:(Вн_О)_(Шл.Гд-10.ЭППС-100.ЦПРФв-40.ЦПС-80/120.ТП-60)_290/330", PredefinedType="FLOOR", context=body_context, shape_type="SweptSolid", body=[
    extrude(rectangle(XDim=880.0, YDim=2090.0, at=frame_2d((0.0, 0.0), x_axis=(1.0, 0.0))), frame((24450.0, 919.5, 280.0), z_axis=(0.0, 0.0, -1.0), x_axis=(0.0, 1.0, 0.0)), (0.0, 0.0, 1.0), 330.0),
])
ifc_layer_usage_6 = layer_usage(ifc_layer_set_3, "AXIS3", "POSITIVE", 0.0)
slab_type_6 = type_object("IfcSlabType", Name="Перекрытие:(Вн_О)_(Шл.Гд-10.ЭППС-100.ЦПРФв-40.ЦПС-80/110.ТП-60)_290/320", PredefinedType="FLOOR", material=ifc_layer_set_3)
slab_6_placement = place(storey_placement, origin())
element("IfcSlab", 6, at=slab_6_placement, inside=storey, type_object=slab_type_6, material=ifc_layer_usage_6, Name="Перекрытие:(Вн_О)_(Шл.Гд-10.ЭППС-100.ЦПРФв-40.ЦПС-80/110.ТП-60)_290/320:22904110", ObjectType="Перекрытие:(Вн_О)_(Шл.Гд-10.ЭППС-100.ЦПРФв-40.ЦПС-80/110.ТП-60)_290/320", PredefinedType="FLOOR", context=body_context, shape_type="SweptSolid", body=[
    extrude(rectangle(XDim=881.3, YDim=2090.0, at=origin_2d_with_axis()), frame((21200.0, 920.2, 270.0), z_axis=(0.0, 0.0, -1.0), x_axis=(0.0, 1.0, 0.0)), (0.0, 0.0, 1.0), 320.0),
])
ifc_layer_usage_7 = layer_usage(ifc_layer_set_3, "AXIS3", "POSITIVE", 0.0)
slab_type_7 = type_object("IfcSlabType", Name="Перекрытие:(Вн_О)_(Шл.Гд-10.ЭППС-100.ЦПРФв-40.ЦПС-80/110.ТП-60)_290/320", PredefinedType="FLOOR", material=ifc_layer_set_3)
slab_7_placement = place(storey_placement, origin())
element("IfcSlab", 7, at=slab_7_placement, inside=storey, type_object=slab_type_7, material=ifc_layer_usage_7, Name="Перекрытие:(Вн_О)_(Шл.Гд-10.ЭППС-100.ЦПРФв-40.ЦПС-80/110.ТП-60)_290/320:22904131", ObjectType="Перекрытие:(Вн_О)_(Шл.Гд-10.ЭППС-100.ЦПРФв-40.ЦПС-80/110.ТП-60)_290/320", PredefinedType="FLOOR", context=body_context, shape_type="SweptSolid", body=[
    extrude(rectangle(XDim=881.2, YDim=1960.0, at=frame_2d((0.0, 0.0), x_axis=(1.0, 0.0))), frame((14635.0, 920.2, 270.0), z_axis=(0.0, 0.0, -1.0), x_axis=(0.0, 1.0, 0.0)), (0.0, 0.0, 1.0), 320.0),
])
ifc_layer_usage_8 = layer_usage(ifc_layer_set_3, "AXIS3", "POSITIVE", 0.0)
slab_type_8 = type_object("IfcSlabType", Name="Перекрытие:(Вн_О)_(Шл.Гд-10.ЭППС-100.ЦПРФв-40.ЦПС-80/110.ТП-60)_290/320", PredefinedType="FLOOR", material=ifc_layer_set_3)
slab_8_placement = place(storey_placement, origin())
element("IfcSlab", 8, at=slab_8_placement, inside=storey, type_object=slab_type_8, material=ifc_layer_usage_8, Name="Перекрытие:(Вн_О)_(Шл.Гд-10.ЭППС-100.ЦПРФв-40.ЦПС-80/110.ТП-60)_290/320:22904144", ObjectType="Перекрытие:(Вн_О)_(Шл.Гд-10.ЭППС-100.ЦПРФв-40.ЦПС-80/110.ТП-60)_290/320", PredefinedType="FLOOR", context=body_context, shape_type="SweptSolid", body=[
    extrude(rectangle(XDim=880.0, YDim=2090.0, at=frame_2d((0.0, 0.0), x_axis=(1.0, 0.0))), frame((11450.0, 919.5, 270.0), z_axis=(0.0, 0.0, -1.0), x_axis=(0.0, 1.0, 0.0)), (0.0, 0.0, 1.0), 320.0),
])
ifc_layer_usage_9 = layer_usage(ifc_layer_set_4, "AXIS3", "POSITIVE", 0.0)
slab_type_9 = type_object("IfcSlabType", Name="Перекрытие:(Вн_О)_(Шл.Гд-10.ЭППС-100.ЦПРФв-40.ЦПС-80/120.ТП-60)_290/330", PredefinedType="FLOOR", material=ifc_layer_set_4)
slab_9_placement = place(storey_placement, origin())
element("IfcSlab", 9, at=slab_9_placement, inside=storey, type_object=slab_type_9, material=ifc_layer_usage_9, Name="Перекрытие:(Вн_О)_(Шл.Гд-10.ЭППС-100.ЦПРФв-40.ЦПС-80/120.ТП-60)_290/330:22904161", ObjectType="Перекрытие:(Вн_О)_(Шл.Гд-10.ЭППС-100.ЦПРФв-40.ЦПС-80/120.ТП-60)_290/330", PredefinedType="FLOOR", context=body_context, shape_type="SweptSolid", body=[
    extrude(rectangle(XDim=880.0, YDim=2090.0, at=frame_2d((0.0, 0.0), x_axis=(1.0, 0.0))), frame((8200.0, 919.5, 280.0), z_axis=(0.0, 0.0, -1.0), x_axis=(0.0, 1.0, 0.0)), (0.0, 0.0, 1.0), 330.0),
])

# Wall, opening
ifc_material_15 = material(Name="M.110.01.22 Утеплитель базальтовый ρ=110-130 кг/м3, λ≤0,041 Вт/м°С, толщ.150 мм", Category="Общего типа")
ifc_layer_29 = layer(ifc_material_15, 150.0, Name="M.110.01.22 Утеплитель базальтовый ρ=110-130 кг/м3, λ≤0,041 Вт/м°С, толщ.150 мм", Category="Общего типа")
ifc_layer_set_5 = layer_set([ifc_layer_29], Name="Базовая стена:(Вн)_(МНВ-150)_150")
ifc_layer_usage_10 = layer_usage(ifc_layer_set_5, "AXIS2", "POSITIVE", -75.0)
wall_type_1 = type_object("IfcWallType", Name="Базовая стена:(Вн)_(МНВ-150)_150", PredefinedType="NOTDEFINED", material=ifc_layer_set_5)
wall_1_placement = place(storey_placement, frame((-1975.0, 779.5, 150.0), z_axis=(0.0, 0.0, 1.0), x_axis=(0.0, 1.0, 0.0)))
wall_1 = element("IfcWall", 10, at=wall_1_placement, inside=storey, type_object=wall_type_1, material=ifc_layer_usage_10, Name="Базовая стена:(Вн)_(МНВ-150)_150:21469479", ObjectType="Базовая стена:(Вн)_(МНВ-150)_150", PredefinedType="NOTDEFINED", context=body_context, shape_type="SweptSolid", body=[
    extrude(rectangle(XDim=2900.0, YDim=150.0, at=frame_2d((1450.0, 0.0), x_axis=(-1.0, 0.0))), origin(), (0.0, 0.0, 1.0), 2850.0),
])
opening_1_placement = place(wall_1_placement, origin())
element("IfcOpeningElement", 11, at=opening_1_placement, cuts=wall_1, ObjectType="Opening", PredefinedType="OPENING", context=body_context, shape_type="SweptSolid", body=[
    extrude(rectangle(XDim=350.0, YDim=925.0, at=frame_2d((0.0, 0.0), x_axis=(1.0, 0.0))), frame((2362.5, 75.0, 2675.0), z_axis=(0.0, -1.0, 0.0), x_axis=(0.0, 0.0, 1.0)), (0.0, 0.0, 1.0), 150.0),
])

save(model, "model.ifc")
